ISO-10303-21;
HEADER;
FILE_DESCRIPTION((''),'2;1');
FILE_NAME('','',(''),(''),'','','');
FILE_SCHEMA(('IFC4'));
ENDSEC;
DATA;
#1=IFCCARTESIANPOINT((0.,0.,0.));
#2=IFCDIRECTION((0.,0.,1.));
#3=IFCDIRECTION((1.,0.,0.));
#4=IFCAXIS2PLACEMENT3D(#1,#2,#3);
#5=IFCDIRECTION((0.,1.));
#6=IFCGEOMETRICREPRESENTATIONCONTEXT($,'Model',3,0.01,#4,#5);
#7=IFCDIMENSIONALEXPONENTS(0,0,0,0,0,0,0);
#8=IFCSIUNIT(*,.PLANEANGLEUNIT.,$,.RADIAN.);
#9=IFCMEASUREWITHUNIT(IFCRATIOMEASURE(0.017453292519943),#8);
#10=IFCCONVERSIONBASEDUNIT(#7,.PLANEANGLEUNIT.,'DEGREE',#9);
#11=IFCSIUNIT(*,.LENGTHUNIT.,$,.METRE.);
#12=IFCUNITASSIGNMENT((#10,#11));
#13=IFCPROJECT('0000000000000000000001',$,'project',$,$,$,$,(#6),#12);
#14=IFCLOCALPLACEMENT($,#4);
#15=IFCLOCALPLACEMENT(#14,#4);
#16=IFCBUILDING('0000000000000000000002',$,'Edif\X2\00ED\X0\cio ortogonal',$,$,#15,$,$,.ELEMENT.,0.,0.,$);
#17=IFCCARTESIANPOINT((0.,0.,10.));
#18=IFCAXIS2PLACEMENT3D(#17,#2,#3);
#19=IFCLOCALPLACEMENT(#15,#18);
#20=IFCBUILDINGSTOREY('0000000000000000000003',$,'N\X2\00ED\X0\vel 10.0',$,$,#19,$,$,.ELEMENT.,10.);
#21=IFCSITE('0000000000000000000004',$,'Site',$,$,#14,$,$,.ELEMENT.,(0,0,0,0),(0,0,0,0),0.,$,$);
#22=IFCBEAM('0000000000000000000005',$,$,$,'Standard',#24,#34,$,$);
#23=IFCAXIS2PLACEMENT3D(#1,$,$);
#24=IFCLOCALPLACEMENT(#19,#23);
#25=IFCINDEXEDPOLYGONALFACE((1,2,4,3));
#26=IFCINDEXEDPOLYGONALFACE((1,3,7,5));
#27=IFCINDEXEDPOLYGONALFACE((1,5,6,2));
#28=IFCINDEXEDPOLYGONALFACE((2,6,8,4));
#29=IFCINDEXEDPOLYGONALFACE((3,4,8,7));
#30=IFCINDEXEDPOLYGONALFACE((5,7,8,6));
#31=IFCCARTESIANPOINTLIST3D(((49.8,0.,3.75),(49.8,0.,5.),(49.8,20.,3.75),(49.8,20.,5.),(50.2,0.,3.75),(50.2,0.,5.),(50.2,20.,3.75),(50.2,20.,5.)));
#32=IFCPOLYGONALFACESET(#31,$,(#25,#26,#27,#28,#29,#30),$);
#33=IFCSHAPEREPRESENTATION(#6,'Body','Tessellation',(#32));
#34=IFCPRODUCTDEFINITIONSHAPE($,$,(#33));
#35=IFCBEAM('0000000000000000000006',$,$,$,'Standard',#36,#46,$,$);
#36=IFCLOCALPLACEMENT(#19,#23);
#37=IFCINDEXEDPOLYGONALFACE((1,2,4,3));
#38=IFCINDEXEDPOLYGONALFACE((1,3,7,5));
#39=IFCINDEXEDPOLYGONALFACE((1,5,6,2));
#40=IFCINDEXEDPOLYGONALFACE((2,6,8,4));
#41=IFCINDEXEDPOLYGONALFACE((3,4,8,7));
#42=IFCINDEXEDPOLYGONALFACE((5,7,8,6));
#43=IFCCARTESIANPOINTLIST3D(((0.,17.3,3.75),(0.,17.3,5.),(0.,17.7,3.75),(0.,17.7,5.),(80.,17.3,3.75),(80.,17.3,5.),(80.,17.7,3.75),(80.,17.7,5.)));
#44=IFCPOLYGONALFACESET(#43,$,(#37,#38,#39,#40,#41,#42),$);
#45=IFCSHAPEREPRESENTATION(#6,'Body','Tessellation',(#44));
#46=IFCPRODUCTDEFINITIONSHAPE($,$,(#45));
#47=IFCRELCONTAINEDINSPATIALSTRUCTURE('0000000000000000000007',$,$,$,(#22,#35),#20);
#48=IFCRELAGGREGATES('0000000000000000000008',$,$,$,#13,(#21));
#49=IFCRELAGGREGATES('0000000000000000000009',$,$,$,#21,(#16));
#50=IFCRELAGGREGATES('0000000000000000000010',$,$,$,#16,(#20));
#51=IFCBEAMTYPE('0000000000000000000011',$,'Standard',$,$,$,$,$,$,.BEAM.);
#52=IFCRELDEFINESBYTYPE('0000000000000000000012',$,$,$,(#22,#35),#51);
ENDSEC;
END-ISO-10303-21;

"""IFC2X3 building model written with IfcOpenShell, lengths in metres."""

from ifc_helpers import new_model, entity, si_unit, converted_unit, direction, frame, origin_with_axes, origin_2d, place, context, project, spatial, rectangle, extrude, type_object, element, save


model = new_model("IFC2X3")

# Units and contexts
model_context = context("Model", 3, precision=0.01, world=origin_with_axes(), true_north=direction((0.0, 1.0)))
ifc_project = project(units=[converted_unit("PLANEANGLEUNIT", "DEGREE", entity("IfcRatioMeasure", 0.017453292519943), si_unit("PLANEANGLEUNIT", "RADIAN"), dimensions=[0, 0, 0, 0, 0, 0, 0]), si_unit("LENGTHUNIT", "METRE")], contexts=[model_context])

# Site, building, storey
site_placement = place(None, origin_with_axes())
site = spatial("IfcSite", under=ifc_project, at=site_placement, Name="Site", CompositionType="ELEMENT", RefLatitude=(0, 0, 0, 0), RefLongitude=(0, 0, 0, 0), RefElevation=0.0)
building_placement = place(site_placement, origin_with_axes())
building = spatial("IfcBuilding", under=site, at=building_placement, Name="Edifício ortogonal", CompositionType="ELEMENT", ElevationOfRefHeight=0.0, ElevationOfTerrain=0.0)
storey_placement = place(building_placement, frame((0.0, 0.0, 10.0), z_axis=(0.0, 0.0, 1.0), x_axis=(1.0, 0.0, 0.0)))
storey = spatial("IfcBuildingStorey", under=building, at=storey_placement, Name="Nível 10.0", CompositionType="ELEMENT", Elevation=10.0)

# Beams
beam_type = type_object("IfcBeamType", Name="Standard", PredefinedType="BEAM")
for number, where, z_axis, x_axis in (
    (1, (50.0, 20.0, 15.0), (0.0, 0.0, 1.0), (0.0, -1.0, 0.0)),
):
    element("IfcBeam", number, at=place(site_placement, frame(where, z_axis=z_axis, x_axis=x_axis)), inside=storey, type_object=beam_type, ObjectType="Standard", context=model_context, shape_type="SweptSolid", body=[
        extrude(rectangle(XDim=0.4, YDim=1.25, at=origin_2d()), frame((0.0, 0.0, -0.625), z_axis=(1.0, 0.0, 0.0), x_axis=(0.0, 1.0, 0.0)), (0.0, 0.0, 1.0), 20.0),
    ])
beam_placement = place(site_placement, frame((80.0, 17.5, 15.0), z_axis=(0.0, 0.0, 1.0), x_axis=(-1.0, 0.0, 0.0)))
element("IfcBeam", 2, at=beam_placement, inside=storey, type_object=beam_type, ObjectType="Standard", context=model_context, shape_type="SweptSolid", body=[
    extrude(rectangle(XDim=0.4, YDim=1.25, at=origin_2d()), frame((0.0, 0.0, -0.625), z_axis=(1.0, 0.0, 0.0), x_axis=(0.0, 1.0, 0.0)), (0.0, 0.0, 1.0), 80.0),
])

save(model, "model.ifc")
